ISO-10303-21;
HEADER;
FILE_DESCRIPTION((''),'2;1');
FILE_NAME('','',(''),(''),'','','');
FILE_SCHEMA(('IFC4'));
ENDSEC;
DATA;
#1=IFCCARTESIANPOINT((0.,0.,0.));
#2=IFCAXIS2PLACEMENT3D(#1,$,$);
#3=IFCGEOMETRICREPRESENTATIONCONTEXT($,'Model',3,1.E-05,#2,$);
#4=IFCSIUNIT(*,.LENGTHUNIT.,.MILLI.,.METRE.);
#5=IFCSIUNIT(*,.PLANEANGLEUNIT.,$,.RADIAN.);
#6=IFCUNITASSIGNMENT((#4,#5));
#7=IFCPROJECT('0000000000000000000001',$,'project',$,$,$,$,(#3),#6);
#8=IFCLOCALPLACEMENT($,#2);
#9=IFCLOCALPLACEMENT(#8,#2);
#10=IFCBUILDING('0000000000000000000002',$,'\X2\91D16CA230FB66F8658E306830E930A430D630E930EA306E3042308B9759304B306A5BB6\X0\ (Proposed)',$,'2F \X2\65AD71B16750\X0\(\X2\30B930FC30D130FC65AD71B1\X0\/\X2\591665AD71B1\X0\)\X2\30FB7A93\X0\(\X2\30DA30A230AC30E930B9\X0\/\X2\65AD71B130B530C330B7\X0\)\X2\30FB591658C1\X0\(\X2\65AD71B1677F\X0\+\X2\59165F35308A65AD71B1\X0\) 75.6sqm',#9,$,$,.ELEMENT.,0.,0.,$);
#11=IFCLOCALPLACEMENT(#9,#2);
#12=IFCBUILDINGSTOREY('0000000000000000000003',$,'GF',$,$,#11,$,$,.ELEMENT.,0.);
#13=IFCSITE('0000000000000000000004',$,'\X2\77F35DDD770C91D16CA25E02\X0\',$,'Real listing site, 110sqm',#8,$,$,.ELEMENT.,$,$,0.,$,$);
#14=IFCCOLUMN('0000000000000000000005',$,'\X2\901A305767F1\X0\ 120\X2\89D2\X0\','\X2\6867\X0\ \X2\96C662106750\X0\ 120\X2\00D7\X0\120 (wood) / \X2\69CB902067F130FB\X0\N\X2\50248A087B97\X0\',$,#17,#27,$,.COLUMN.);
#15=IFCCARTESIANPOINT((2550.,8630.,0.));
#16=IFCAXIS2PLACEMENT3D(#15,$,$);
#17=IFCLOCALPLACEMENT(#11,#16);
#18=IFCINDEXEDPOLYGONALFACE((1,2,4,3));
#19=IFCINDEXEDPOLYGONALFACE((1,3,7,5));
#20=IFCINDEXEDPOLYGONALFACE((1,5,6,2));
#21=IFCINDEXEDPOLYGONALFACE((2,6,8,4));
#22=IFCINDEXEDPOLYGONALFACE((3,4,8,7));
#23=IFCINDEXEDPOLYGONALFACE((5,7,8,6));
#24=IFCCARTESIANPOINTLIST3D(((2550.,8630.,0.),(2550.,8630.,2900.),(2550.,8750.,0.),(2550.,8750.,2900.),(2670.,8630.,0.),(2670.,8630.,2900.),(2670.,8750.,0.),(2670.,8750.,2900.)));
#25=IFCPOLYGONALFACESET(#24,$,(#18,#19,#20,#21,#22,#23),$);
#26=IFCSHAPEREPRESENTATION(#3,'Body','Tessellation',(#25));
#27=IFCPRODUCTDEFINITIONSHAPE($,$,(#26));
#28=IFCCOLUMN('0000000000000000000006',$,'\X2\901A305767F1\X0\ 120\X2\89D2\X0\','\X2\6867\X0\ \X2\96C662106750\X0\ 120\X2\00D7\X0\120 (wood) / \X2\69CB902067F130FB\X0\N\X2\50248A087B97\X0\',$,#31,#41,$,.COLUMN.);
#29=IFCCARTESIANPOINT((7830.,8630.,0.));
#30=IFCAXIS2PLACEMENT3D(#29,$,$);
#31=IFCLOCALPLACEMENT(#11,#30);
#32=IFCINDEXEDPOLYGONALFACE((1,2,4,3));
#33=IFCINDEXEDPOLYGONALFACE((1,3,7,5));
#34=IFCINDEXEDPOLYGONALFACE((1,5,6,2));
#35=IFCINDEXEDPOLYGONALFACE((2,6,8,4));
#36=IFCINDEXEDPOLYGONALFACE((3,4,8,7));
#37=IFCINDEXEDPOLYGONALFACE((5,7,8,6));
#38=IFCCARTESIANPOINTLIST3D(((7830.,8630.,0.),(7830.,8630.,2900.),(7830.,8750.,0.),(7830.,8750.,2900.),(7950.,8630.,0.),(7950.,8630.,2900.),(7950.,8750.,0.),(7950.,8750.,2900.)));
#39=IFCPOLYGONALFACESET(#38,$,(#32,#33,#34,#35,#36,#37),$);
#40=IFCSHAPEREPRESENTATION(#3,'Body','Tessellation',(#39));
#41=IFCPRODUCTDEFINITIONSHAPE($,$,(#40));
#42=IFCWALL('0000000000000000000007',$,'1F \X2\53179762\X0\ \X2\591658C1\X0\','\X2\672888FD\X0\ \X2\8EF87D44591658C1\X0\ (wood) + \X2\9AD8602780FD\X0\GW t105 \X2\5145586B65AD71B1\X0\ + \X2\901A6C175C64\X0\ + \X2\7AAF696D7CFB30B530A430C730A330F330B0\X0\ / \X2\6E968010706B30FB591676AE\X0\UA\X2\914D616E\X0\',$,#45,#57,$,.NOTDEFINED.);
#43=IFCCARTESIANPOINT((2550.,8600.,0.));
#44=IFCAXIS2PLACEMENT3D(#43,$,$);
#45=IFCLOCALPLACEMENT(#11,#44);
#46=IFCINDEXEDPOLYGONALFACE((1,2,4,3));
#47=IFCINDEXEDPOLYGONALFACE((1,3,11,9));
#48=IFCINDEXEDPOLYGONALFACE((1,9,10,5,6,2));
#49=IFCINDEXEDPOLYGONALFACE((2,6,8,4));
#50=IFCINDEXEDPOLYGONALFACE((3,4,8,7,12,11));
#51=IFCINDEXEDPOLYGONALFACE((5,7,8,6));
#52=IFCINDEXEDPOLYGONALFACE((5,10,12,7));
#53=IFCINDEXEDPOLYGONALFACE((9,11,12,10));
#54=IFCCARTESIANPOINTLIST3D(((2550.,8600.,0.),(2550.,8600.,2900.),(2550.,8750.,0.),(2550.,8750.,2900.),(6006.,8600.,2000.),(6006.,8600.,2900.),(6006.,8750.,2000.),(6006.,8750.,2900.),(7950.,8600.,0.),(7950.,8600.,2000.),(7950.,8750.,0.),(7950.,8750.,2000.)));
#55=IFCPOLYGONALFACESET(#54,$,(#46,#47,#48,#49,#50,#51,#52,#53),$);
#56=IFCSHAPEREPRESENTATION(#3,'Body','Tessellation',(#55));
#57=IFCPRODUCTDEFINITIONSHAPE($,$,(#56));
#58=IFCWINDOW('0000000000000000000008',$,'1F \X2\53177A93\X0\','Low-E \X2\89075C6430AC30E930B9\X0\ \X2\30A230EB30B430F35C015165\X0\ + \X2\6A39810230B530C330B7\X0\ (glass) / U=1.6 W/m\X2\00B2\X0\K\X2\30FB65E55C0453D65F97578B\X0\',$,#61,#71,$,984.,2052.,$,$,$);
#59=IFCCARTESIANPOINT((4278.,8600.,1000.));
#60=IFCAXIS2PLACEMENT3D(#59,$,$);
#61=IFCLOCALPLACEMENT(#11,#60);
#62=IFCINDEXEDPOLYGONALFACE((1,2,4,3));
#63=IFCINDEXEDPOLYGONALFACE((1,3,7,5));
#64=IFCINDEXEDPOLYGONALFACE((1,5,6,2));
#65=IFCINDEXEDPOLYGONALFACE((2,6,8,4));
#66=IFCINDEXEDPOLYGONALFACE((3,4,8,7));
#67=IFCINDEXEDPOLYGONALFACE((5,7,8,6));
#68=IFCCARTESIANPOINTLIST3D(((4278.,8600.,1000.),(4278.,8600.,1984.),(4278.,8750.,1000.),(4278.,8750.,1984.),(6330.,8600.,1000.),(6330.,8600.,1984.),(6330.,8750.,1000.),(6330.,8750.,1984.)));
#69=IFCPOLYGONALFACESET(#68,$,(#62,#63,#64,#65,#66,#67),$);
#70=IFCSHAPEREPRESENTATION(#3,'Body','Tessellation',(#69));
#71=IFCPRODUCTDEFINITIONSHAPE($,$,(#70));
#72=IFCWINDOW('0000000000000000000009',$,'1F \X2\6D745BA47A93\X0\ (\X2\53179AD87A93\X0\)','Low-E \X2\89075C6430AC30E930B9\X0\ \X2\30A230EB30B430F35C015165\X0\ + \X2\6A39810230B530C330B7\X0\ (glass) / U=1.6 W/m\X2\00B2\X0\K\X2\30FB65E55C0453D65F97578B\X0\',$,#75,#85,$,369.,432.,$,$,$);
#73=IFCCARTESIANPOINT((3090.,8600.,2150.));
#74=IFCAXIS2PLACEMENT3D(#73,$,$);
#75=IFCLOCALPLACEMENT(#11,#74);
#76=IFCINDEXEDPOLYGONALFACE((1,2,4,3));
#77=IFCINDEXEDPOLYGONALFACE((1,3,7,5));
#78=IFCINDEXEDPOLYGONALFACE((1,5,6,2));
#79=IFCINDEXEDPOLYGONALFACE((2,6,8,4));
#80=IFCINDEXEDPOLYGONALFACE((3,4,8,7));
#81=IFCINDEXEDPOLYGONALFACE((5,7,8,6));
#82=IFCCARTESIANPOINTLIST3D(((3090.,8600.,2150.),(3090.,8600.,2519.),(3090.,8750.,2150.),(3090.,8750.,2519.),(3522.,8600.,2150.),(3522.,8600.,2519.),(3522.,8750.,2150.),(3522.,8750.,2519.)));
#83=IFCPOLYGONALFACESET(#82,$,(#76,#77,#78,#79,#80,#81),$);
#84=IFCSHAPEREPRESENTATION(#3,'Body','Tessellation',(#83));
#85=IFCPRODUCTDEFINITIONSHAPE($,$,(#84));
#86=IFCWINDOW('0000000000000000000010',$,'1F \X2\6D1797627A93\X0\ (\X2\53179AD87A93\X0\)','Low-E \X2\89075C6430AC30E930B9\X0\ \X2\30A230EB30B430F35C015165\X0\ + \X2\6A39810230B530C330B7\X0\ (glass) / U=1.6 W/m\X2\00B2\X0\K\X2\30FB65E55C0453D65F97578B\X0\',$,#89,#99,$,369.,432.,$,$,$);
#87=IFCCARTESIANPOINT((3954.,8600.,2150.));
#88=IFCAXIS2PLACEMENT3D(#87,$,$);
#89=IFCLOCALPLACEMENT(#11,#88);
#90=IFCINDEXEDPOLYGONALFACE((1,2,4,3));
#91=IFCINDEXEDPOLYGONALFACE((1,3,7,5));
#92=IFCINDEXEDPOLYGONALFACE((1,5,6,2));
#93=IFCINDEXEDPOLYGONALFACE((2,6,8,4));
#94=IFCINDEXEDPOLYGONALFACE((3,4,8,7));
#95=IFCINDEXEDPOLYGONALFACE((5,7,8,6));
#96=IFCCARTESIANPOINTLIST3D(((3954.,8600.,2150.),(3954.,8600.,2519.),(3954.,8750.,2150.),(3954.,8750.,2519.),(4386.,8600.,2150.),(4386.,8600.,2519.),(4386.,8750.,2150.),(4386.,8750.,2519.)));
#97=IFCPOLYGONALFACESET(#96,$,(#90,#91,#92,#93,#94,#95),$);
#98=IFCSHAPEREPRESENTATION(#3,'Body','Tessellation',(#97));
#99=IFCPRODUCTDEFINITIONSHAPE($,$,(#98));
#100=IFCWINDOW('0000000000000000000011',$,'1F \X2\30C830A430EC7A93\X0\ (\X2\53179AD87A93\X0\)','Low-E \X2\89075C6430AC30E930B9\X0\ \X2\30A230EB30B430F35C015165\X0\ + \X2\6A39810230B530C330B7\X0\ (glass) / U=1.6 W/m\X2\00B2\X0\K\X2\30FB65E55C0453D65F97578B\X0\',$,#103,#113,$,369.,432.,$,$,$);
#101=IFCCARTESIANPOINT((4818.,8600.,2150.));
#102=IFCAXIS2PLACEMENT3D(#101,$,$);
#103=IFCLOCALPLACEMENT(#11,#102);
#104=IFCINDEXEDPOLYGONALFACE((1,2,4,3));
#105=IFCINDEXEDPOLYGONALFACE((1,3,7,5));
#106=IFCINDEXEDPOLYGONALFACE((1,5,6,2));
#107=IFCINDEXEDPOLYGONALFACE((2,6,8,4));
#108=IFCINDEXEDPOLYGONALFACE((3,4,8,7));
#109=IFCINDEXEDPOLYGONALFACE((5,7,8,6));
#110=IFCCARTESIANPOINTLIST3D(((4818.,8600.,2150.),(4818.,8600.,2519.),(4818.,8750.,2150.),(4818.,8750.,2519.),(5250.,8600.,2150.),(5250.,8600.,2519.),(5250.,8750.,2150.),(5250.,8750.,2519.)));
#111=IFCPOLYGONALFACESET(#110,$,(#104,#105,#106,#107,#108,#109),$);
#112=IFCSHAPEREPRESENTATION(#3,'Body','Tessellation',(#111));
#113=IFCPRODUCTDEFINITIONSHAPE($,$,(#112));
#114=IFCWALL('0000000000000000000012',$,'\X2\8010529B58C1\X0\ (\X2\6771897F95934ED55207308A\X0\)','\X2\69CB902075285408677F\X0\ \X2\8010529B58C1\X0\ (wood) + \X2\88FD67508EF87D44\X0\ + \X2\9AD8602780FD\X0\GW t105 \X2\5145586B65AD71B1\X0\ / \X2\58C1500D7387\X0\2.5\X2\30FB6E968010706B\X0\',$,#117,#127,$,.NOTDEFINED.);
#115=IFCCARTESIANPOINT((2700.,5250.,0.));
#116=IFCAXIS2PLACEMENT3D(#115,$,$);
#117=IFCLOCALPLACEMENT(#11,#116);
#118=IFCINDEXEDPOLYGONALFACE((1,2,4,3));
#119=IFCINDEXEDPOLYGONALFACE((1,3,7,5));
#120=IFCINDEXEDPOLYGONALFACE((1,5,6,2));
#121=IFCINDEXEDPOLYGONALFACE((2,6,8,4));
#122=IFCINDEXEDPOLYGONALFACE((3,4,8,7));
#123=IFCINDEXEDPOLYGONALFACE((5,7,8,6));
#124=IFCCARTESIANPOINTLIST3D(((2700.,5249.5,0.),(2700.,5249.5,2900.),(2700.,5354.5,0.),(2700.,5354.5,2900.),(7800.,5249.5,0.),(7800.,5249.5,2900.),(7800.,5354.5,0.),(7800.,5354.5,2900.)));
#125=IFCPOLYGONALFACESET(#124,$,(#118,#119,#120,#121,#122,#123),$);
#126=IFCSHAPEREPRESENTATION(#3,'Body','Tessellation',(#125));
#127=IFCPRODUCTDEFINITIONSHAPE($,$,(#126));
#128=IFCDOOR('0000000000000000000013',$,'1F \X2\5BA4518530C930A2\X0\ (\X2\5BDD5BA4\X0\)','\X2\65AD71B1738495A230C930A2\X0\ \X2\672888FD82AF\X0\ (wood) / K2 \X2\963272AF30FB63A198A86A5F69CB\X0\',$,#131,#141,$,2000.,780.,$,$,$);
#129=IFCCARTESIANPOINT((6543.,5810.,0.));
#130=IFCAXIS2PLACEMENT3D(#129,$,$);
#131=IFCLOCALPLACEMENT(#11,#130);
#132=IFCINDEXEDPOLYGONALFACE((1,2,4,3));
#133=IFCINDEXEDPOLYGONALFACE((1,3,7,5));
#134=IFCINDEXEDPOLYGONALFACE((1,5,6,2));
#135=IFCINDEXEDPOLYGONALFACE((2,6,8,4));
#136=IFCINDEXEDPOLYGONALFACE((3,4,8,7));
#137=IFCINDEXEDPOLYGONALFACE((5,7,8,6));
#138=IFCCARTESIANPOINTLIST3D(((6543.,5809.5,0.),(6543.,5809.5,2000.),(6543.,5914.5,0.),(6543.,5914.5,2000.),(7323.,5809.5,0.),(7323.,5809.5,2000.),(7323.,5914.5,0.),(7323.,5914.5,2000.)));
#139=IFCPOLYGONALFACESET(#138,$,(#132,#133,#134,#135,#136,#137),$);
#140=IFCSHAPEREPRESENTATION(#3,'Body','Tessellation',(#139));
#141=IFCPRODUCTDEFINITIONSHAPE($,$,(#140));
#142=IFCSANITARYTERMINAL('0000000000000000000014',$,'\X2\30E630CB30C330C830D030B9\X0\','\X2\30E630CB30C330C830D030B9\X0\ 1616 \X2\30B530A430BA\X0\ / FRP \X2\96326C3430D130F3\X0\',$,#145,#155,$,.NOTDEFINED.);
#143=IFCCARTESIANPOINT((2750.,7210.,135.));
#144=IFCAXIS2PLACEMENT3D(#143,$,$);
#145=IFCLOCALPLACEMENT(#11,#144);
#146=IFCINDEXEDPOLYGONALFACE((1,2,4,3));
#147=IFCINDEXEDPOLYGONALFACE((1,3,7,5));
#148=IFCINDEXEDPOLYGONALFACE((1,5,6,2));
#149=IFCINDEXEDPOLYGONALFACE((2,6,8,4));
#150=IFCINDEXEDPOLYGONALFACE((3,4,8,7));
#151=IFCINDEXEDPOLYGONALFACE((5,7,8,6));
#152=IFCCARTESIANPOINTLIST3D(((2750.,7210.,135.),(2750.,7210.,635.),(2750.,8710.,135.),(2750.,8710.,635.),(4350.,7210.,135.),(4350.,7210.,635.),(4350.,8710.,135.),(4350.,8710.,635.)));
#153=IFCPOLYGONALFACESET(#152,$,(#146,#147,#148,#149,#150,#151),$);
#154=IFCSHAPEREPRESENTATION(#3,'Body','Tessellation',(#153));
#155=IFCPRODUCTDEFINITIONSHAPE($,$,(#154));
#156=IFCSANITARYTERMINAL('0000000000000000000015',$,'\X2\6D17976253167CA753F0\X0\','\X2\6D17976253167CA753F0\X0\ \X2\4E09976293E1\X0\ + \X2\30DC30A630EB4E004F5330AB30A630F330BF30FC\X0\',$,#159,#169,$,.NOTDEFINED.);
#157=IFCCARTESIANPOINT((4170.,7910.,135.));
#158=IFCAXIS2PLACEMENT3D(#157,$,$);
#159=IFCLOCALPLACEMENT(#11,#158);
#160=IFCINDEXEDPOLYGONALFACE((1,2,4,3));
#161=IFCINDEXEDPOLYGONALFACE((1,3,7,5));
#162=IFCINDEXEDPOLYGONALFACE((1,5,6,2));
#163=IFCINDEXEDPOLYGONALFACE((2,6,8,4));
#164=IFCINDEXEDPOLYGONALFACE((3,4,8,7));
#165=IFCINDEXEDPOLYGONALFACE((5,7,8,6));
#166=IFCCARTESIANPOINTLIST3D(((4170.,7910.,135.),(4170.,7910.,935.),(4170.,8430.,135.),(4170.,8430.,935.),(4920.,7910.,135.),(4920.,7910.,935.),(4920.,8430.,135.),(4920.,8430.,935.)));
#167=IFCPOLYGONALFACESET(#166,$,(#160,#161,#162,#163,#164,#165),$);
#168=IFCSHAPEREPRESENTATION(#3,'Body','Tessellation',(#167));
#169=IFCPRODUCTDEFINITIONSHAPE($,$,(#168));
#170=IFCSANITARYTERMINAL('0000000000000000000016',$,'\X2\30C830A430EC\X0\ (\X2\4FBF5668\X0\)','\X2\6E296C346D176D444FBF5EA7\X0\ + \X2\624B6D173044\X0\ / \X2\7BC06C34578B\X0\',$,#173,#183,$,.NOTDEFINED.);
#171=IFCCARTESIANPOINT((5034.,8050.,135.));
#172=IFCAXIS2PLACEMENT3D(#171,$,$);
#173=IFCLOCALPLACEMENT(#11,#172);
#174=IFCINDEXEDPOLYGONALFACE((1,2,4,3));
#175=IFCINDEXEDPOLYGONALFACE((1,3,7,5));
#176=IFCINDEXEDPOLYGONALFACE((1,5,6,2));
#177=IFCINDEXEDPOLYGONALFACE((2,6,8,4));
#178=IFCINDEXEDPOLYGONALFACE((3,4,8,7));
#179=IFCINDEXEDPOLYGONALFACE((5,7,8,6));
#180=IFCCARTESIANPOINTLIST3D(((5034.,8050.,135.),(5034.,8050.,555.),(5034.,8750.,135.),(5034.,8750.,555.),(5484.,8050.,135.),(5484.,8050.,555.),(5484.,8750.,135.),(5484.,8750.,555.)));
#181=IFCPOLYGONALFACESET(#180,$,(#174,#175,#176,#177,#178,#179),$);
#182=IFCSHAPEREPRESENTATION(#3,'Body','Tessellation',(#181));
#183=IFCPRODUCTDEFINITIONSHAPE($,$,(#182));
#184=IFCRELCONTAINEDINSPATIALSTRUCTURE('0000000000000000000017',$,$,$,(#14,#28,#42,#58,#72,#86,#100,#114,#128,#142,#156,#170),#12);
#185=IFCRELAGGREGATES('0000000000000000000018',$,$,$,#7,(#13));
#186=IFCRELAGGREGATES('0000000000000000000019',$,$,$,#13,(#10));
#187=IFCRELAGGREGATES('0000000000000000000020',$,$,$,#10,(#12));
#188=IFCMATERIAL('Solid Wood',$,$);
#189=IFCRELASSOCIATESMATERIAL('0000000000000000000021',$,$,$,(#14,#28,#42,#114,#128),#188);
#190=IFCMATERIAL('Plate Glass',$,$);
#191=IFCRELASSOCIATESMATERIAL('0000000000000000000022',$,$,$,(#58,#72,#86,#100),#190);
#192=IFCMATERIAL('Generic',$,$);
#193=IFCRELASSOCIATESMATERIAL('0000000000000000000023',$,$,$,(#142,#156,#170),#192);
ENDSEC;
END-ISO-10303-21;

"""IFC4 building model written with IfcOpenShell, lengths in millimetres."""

from ifc_helpers import new_model, si_unit, frame, frame_2d, origin, place, context, project, spatial, rectangle, extrude, material, element, fill, save


model = new_model("IFC4")

# Units and contexts
model_context = context("Model", 3, precision=1e-05, world=origin())
ifc_project = project(units=[si_unit("LENGTHUNIT", "METRE", prefix="MILLI"), si_unit("PLANEANGLEUNIT", "RADIAN")], contexts=[model_context])

# Site, building, storey
site_placement = place(None, origin())
site = spatial("IfcSite", under=ifc_project, at=site_placement, Name="石川県金沢市", ObjectType="Real listing site, 110sqm", CompositionType="ELEMENT", RefElevation=0.0)
building_placement = place(site_placement, origin())
building = spatial("IfcBuilding", under=site, at=building_placement, Name="金沢・書斎とライブラリのある静かな家 (Proposed)", ObjectType="2F 断熱材(スーパー断熱/外断熱)・窓(ペアガラス/断熱サッシ)・外壁(断熱板+外張り断熱) 75.6sqm", CompositionType="ELEMENT", ElevationOfRefHeight=0.0, ElevationOfTerrain=0.0)
storey_placement = place(building_placement, origin())
storey = spatial("IfcBuildingStorey", under=building, at=storey_placement, Name="GF", CompositionType="ELEMENT", Elevation=0.0)

# Columns
ifc_material_1 = material(Name="Solid Wood")
column_1_placement = place(storey_placement, frame((2550.0, 8630.0, 0.0)))
element("IfcColumn", 1, at=column_1_placement, inside=storey, material=ifc_material_1, Name="通し柱 120角", Description="桧 集成材 120×120 (wood) / 構造柱・N値計算", PredefinedType="COLUMN", context=model_context, shape_type="SweptSolid", body=[
    extrude(rectangle(XDim=120.0, YDim=120.0, at=frame_2d((60.0, 60.0))), frame((2550.0, 8630.0, 0.0)), (0.0, 0.0, 1.0), 2900.0),
])
column_2_placement = place(storey_placement, frame((7830.0, 8630.0, 0.0)))
element("IfcColumn", 2, at=column_2_placement, inside=storey, material=ifc_material_1, Name="通し柱 120角", Description="桧 集成材 120×120 (wood) / 構造柱・N値計算", PredefinedType="COLUMN", context=model_context, shape_type="SweptSolid", body=[
    extrude(rectangle(XDim=120.0, YDim=120.0, at=frame_2d((60.0, 60.0))), frame((7830.0, 8630.0, 0.0)), (0.0, 0.0, 1.0), 2900.0),
])

# Wall, openings, windows
wall_1_placement = place(storey_placement, frame((2550.0, 8600.0, 0.0)))
wall_1 = element("IfcWall", 3, at=wall_1_placement, inside=storey, material=ifc_material_1, Name="1F 北面 外壁", Description="木製 軸組外壁 (wood) + 高性能GW t105 充填断熱 + 通気層 + 窯業系サイディング / 準耐火・外皮UA配慮", PredefinedType="NOTDEFINED", context=model_context, shape_type="SweptSolid", body=[
    extrude(rectangle(XDim=5400.0, YDim=150.0, at=frame_2d((2700.0, 75.0))), frame((2550.0, 8600.0, 0.0)), (0.0, 0.0, 1.0), 2900.0),
])
opening_1_placement = place(storey_placement, frame((4278.0, 8600.0, 1000.0)))
opening_1 = element("IfcOpeningElement", 4, at=opening_1_placement, cuts=wall_1, PredefinedType="NOTDEFINED", context=model_context, shape_type="SweptSolid", body=[
    extrude(rectangle(XDim=2052.0, YDim=150.0, at=frame_2d((1026.0, 75.0))), frame((4278.0, 8600.0, 1000.0)), (0.0, 0.0, 1.0), 984.0),
])
opening_2_placement = place(storey_placement, frame((3090.0, 8600.0, 2150.0)))
opening_2 = element("IfcOpeningElement", 5, at=opening_2_placement, cuts=wall_1, PredefinedType="NOTDEFINED", context=model_context, shape_type="SweptSolid", body=[
    extrude(rectangle(XDim=432.0, YDim=150.0, at=frame_2d((216.0, 75.0))), frame((3090.0, 8600.0, 2150.0)), (0.0, 0.0, 1.0), 369.0),
])
opening_3_placement = place(storey_placement, frame((3954.0, 8600.0, 2150.0)))
opening_3 = element("IfcOpeningElement", 6, at=opening_3_placement, cuts=wall_1, PredefinedType="NOTDEFINED", context=model_context, shape_type="SweptSolid", body=[
    extrude(rectangle(XDim=432.0, YDim=150.0, at=frame_2d((216.0, 75.0))), frame((3954.0, 8600.0, 2150.0)), (0.0, 0.0, 1.0), 369.0),
])
opening_4_placement = place(storey_placement, frame((4818.0, 8600.0, 2150.0)))
opening_4 = element("IfcOpeningElement", 7, at=opening_4_placement, cuts=wall_1, PredefinedType="NOTDEFINED", context=model_context, shape_type="SweptSolid", body=[
    extrude(rectangle(XDim=432.0, YDim=150.0, at=frame_2d((216.0, 75.0))), frame((4818.0, 8600.0, 2150.0)), (0.0, 0.0, 1.0), 369.0),
])
ifc_material_2 = material(Name="Plate Glass")
window_1_placement = place(storey_placement, frame((4278.0, 8600.0, 1000.0)))
window_1 = element("IfcWindow", 8, at=window_1_placement, inside=storey, material=ifc_material_2, Name="1F 北窓", Description="Low-E 複層ガラス アルゴン封入 + 樹脂サッシ (glass) / U=1.6 W/m²K・日射取得型", OverallHeight=984.0, OverallWidth=2052.0, context=model_context, shape_type="SweptSolid", body=[
    extrude(rectangle(XDim=2052.0, YDim=150.0, at=frame_2d((1026.0, 75.0))), frame((4278.0, 8600.0, 1000.0)), (0.0, 0.0, 1.0), 984.0),
])
fill(opening_1, window_1)
window_2_placement = place(storey_placement, frame((3090.0, 8600.0, 2150.0)))
window_2 = element("IfcWindow", 9, at=window_2_placement, inside=storey, material=ifc_material_2, Name="1F 浴室窓 (北高窓)", Description="Low-E 複層ガラス アルゴン封入 + 樹脂サッシ (glass) / U=1.6 W/m²K・日射取得型", OverallHeight=369.0, OverallWidth=432.0, context=model_context, shape_type="SweptSolid", body=[
    extrude(rectangle(XDim=432.0, YDim=150.0, at=frame_2d((216.0, 75.0))), frame((3090.0, 8600.0, 2150.0)), (0.0, 0.0, 1.0), 369.0),
])
fill(opening_2, window_2)
window_3_placement = place(storey_placement, frame((3954.0, 8600.0, 2150.0)))
window_3 = element("IfcWindow", 10, at=window_3_placement, inside=storey, material=ifc_material_2, Name="1F 洗面窓 (北高窓)", Description="Low-E 複層ガラス アルゴン封入 + 樹脂サッシ (glass) / U=1.6 W/m²K・日射取得型", OverallHeight=369.0, OverallWidth=432.0, context=model_context, shape_type="SweptSolid", body=[
    extrude(rectangle(XDim=432.0, YDim=150.0, at=frame_2d((216.0, 75.0))), frame((3954.0, 8600.0, 2150.0)), (0.0, 0.0, 1.0), 369.0),
])
fill(opening_3, window_3)
window_4_placement = place(storey_placement, frame((4818.0, 8600.0, 2150.0)))
window_4 = element("IfcWindow", 11, at=window_4_placement, inside=storey, material=ifc_material_2, Name="1F トイレ窓 (北高窓)", Description="Low-E 複層ガラス アルゴン封入 + 樹脂サッシ (glass) / U=1.6 W/m²K・日射取得型", OverallHeight=369.0, OverallWidth=432.0, context=model_context, shape_type="SweptSolid", body=[
    extrude(rectangle(XDim=432.0, YDim=150.0, at=frame_2d((216.0, 75.0))), frame((4818.0, 8600.0, 2150.0)), (0.0, 0.0, 1.0), 369.0),
])
fill(opening_4, window_4)

# Wall
wall_2_placement = place(storey_placement, frame((2700.0, 5250.0, 0.0)))
element("IfcWall", 12, at=wall_2_placement, inside=storey, material=ifc_material_1, Name="耐力壁 (東西間仕切り)", Description="構造用合板 耐力壁 (wood) + 製材軸組 + 高性能GW t105 充填断熱 / 壁倍率2.5・準耐火", PredefinedType="NOTDEFINED", context=model_context, shape_type="SweptSolid", body=[
    extrude(rectangle(XDim=5100.0, YDim=105.0, at=frame_2d((2550.0, 52.0))), frame((2700.0, 5250.0, 0.0)), (0.0, 0.0, 1.0), 2900.0),
])

# Door
door_1_placement = place(storey_placement, frame((6543.0, 5810.0, 0.0)))
element("IfcDoor", 13, at=door_1_placement, inside=storey, material=ifc_material_1, Name="1F 室内ドア (寝室)", Description="断熱玄関ドア 木製芯 (wood) / K2 防犯・採風機構", OverallHeight=2000.0, OverallWidth=780.0, context=model_context, shape_type="SweptSolid", body=[
    extrude(rectangle(XDim=780.0, YDim=105.0, at=frame_2d((390.0, 52.0))), frame((6543.0, 5810.0, 0.0)), (0.0, 0.0, 1.0), 2000.0),
])

# Sanitary terminals
ifc_material_3 = material(Name="Generic")
sanitary_terminal_1_placement = place(storey_placement, frame((2750.0, 7210.0, 135.0)))
element("IfcSanitaryTerminal", 14, at=sanitary_terminal_1_placement, inside=storey, material=ifc_material_3, Name="ユニットバス", Description="ユニットバス 1616 サイズ / FRP 防水パン", PredefinedType="NOTDEFINED", context=model_context, shape_type="SweptSolid", body=[
    extrude(rectangle(XDim=1600.0, YDim=1500.0, at=frame_2d((800.0, 750.0))), frame((2750.0, 7210.0, 135.0)), (0.0, 0.0, 1.0), 500.0),
])
sanitary_terminal_2_placement = place(storey_placement, frame((4170.0, 7910.0, 135.0)))
element("IfcSanitaryTerminal", 15, at=sanitary_terminal_2_placement, inside=storey, material=ifc_material_3, Name="洗面化粧台", Description="洗面化粧台 三面鏡 + ボウル一体カウンター", PredefinedType="NOTDEFINED", context=model_context, shape_type="SweptSolid", body=[
    extrude(rectangle(XDim=750.0, YDim=520.0, at=frame_2d((375.0, 260.0))), frame((4170.0, 7910.0, 135.0)), (0.0, 0.0, 1.0), 800.0),
])
sanitary_terminal_3_placement = place(storey_placement, frame((5034.0, 8050.0, 135.0)))
element("IfcSanitaryTerminal", 16, at=sanitary_terminal_3_placement, inside=storey, material=ifc_material_3, Name="トイレ (便器)", Description="温水洗浄便座 + 手洗い / 節水型", PredefinedType="NOTDEFINED", context=model_context, shape_type="SweptSolid", body=[
    extrude(rectangle(XDim=450.0, YDim=700.0, at=frame_2d((225.0, 350.0))), frame((5034.0, 8050.0, 135.0)), (0.0, 0.0, 1.0), 420.0),
])

save(model, "model.ifc")
